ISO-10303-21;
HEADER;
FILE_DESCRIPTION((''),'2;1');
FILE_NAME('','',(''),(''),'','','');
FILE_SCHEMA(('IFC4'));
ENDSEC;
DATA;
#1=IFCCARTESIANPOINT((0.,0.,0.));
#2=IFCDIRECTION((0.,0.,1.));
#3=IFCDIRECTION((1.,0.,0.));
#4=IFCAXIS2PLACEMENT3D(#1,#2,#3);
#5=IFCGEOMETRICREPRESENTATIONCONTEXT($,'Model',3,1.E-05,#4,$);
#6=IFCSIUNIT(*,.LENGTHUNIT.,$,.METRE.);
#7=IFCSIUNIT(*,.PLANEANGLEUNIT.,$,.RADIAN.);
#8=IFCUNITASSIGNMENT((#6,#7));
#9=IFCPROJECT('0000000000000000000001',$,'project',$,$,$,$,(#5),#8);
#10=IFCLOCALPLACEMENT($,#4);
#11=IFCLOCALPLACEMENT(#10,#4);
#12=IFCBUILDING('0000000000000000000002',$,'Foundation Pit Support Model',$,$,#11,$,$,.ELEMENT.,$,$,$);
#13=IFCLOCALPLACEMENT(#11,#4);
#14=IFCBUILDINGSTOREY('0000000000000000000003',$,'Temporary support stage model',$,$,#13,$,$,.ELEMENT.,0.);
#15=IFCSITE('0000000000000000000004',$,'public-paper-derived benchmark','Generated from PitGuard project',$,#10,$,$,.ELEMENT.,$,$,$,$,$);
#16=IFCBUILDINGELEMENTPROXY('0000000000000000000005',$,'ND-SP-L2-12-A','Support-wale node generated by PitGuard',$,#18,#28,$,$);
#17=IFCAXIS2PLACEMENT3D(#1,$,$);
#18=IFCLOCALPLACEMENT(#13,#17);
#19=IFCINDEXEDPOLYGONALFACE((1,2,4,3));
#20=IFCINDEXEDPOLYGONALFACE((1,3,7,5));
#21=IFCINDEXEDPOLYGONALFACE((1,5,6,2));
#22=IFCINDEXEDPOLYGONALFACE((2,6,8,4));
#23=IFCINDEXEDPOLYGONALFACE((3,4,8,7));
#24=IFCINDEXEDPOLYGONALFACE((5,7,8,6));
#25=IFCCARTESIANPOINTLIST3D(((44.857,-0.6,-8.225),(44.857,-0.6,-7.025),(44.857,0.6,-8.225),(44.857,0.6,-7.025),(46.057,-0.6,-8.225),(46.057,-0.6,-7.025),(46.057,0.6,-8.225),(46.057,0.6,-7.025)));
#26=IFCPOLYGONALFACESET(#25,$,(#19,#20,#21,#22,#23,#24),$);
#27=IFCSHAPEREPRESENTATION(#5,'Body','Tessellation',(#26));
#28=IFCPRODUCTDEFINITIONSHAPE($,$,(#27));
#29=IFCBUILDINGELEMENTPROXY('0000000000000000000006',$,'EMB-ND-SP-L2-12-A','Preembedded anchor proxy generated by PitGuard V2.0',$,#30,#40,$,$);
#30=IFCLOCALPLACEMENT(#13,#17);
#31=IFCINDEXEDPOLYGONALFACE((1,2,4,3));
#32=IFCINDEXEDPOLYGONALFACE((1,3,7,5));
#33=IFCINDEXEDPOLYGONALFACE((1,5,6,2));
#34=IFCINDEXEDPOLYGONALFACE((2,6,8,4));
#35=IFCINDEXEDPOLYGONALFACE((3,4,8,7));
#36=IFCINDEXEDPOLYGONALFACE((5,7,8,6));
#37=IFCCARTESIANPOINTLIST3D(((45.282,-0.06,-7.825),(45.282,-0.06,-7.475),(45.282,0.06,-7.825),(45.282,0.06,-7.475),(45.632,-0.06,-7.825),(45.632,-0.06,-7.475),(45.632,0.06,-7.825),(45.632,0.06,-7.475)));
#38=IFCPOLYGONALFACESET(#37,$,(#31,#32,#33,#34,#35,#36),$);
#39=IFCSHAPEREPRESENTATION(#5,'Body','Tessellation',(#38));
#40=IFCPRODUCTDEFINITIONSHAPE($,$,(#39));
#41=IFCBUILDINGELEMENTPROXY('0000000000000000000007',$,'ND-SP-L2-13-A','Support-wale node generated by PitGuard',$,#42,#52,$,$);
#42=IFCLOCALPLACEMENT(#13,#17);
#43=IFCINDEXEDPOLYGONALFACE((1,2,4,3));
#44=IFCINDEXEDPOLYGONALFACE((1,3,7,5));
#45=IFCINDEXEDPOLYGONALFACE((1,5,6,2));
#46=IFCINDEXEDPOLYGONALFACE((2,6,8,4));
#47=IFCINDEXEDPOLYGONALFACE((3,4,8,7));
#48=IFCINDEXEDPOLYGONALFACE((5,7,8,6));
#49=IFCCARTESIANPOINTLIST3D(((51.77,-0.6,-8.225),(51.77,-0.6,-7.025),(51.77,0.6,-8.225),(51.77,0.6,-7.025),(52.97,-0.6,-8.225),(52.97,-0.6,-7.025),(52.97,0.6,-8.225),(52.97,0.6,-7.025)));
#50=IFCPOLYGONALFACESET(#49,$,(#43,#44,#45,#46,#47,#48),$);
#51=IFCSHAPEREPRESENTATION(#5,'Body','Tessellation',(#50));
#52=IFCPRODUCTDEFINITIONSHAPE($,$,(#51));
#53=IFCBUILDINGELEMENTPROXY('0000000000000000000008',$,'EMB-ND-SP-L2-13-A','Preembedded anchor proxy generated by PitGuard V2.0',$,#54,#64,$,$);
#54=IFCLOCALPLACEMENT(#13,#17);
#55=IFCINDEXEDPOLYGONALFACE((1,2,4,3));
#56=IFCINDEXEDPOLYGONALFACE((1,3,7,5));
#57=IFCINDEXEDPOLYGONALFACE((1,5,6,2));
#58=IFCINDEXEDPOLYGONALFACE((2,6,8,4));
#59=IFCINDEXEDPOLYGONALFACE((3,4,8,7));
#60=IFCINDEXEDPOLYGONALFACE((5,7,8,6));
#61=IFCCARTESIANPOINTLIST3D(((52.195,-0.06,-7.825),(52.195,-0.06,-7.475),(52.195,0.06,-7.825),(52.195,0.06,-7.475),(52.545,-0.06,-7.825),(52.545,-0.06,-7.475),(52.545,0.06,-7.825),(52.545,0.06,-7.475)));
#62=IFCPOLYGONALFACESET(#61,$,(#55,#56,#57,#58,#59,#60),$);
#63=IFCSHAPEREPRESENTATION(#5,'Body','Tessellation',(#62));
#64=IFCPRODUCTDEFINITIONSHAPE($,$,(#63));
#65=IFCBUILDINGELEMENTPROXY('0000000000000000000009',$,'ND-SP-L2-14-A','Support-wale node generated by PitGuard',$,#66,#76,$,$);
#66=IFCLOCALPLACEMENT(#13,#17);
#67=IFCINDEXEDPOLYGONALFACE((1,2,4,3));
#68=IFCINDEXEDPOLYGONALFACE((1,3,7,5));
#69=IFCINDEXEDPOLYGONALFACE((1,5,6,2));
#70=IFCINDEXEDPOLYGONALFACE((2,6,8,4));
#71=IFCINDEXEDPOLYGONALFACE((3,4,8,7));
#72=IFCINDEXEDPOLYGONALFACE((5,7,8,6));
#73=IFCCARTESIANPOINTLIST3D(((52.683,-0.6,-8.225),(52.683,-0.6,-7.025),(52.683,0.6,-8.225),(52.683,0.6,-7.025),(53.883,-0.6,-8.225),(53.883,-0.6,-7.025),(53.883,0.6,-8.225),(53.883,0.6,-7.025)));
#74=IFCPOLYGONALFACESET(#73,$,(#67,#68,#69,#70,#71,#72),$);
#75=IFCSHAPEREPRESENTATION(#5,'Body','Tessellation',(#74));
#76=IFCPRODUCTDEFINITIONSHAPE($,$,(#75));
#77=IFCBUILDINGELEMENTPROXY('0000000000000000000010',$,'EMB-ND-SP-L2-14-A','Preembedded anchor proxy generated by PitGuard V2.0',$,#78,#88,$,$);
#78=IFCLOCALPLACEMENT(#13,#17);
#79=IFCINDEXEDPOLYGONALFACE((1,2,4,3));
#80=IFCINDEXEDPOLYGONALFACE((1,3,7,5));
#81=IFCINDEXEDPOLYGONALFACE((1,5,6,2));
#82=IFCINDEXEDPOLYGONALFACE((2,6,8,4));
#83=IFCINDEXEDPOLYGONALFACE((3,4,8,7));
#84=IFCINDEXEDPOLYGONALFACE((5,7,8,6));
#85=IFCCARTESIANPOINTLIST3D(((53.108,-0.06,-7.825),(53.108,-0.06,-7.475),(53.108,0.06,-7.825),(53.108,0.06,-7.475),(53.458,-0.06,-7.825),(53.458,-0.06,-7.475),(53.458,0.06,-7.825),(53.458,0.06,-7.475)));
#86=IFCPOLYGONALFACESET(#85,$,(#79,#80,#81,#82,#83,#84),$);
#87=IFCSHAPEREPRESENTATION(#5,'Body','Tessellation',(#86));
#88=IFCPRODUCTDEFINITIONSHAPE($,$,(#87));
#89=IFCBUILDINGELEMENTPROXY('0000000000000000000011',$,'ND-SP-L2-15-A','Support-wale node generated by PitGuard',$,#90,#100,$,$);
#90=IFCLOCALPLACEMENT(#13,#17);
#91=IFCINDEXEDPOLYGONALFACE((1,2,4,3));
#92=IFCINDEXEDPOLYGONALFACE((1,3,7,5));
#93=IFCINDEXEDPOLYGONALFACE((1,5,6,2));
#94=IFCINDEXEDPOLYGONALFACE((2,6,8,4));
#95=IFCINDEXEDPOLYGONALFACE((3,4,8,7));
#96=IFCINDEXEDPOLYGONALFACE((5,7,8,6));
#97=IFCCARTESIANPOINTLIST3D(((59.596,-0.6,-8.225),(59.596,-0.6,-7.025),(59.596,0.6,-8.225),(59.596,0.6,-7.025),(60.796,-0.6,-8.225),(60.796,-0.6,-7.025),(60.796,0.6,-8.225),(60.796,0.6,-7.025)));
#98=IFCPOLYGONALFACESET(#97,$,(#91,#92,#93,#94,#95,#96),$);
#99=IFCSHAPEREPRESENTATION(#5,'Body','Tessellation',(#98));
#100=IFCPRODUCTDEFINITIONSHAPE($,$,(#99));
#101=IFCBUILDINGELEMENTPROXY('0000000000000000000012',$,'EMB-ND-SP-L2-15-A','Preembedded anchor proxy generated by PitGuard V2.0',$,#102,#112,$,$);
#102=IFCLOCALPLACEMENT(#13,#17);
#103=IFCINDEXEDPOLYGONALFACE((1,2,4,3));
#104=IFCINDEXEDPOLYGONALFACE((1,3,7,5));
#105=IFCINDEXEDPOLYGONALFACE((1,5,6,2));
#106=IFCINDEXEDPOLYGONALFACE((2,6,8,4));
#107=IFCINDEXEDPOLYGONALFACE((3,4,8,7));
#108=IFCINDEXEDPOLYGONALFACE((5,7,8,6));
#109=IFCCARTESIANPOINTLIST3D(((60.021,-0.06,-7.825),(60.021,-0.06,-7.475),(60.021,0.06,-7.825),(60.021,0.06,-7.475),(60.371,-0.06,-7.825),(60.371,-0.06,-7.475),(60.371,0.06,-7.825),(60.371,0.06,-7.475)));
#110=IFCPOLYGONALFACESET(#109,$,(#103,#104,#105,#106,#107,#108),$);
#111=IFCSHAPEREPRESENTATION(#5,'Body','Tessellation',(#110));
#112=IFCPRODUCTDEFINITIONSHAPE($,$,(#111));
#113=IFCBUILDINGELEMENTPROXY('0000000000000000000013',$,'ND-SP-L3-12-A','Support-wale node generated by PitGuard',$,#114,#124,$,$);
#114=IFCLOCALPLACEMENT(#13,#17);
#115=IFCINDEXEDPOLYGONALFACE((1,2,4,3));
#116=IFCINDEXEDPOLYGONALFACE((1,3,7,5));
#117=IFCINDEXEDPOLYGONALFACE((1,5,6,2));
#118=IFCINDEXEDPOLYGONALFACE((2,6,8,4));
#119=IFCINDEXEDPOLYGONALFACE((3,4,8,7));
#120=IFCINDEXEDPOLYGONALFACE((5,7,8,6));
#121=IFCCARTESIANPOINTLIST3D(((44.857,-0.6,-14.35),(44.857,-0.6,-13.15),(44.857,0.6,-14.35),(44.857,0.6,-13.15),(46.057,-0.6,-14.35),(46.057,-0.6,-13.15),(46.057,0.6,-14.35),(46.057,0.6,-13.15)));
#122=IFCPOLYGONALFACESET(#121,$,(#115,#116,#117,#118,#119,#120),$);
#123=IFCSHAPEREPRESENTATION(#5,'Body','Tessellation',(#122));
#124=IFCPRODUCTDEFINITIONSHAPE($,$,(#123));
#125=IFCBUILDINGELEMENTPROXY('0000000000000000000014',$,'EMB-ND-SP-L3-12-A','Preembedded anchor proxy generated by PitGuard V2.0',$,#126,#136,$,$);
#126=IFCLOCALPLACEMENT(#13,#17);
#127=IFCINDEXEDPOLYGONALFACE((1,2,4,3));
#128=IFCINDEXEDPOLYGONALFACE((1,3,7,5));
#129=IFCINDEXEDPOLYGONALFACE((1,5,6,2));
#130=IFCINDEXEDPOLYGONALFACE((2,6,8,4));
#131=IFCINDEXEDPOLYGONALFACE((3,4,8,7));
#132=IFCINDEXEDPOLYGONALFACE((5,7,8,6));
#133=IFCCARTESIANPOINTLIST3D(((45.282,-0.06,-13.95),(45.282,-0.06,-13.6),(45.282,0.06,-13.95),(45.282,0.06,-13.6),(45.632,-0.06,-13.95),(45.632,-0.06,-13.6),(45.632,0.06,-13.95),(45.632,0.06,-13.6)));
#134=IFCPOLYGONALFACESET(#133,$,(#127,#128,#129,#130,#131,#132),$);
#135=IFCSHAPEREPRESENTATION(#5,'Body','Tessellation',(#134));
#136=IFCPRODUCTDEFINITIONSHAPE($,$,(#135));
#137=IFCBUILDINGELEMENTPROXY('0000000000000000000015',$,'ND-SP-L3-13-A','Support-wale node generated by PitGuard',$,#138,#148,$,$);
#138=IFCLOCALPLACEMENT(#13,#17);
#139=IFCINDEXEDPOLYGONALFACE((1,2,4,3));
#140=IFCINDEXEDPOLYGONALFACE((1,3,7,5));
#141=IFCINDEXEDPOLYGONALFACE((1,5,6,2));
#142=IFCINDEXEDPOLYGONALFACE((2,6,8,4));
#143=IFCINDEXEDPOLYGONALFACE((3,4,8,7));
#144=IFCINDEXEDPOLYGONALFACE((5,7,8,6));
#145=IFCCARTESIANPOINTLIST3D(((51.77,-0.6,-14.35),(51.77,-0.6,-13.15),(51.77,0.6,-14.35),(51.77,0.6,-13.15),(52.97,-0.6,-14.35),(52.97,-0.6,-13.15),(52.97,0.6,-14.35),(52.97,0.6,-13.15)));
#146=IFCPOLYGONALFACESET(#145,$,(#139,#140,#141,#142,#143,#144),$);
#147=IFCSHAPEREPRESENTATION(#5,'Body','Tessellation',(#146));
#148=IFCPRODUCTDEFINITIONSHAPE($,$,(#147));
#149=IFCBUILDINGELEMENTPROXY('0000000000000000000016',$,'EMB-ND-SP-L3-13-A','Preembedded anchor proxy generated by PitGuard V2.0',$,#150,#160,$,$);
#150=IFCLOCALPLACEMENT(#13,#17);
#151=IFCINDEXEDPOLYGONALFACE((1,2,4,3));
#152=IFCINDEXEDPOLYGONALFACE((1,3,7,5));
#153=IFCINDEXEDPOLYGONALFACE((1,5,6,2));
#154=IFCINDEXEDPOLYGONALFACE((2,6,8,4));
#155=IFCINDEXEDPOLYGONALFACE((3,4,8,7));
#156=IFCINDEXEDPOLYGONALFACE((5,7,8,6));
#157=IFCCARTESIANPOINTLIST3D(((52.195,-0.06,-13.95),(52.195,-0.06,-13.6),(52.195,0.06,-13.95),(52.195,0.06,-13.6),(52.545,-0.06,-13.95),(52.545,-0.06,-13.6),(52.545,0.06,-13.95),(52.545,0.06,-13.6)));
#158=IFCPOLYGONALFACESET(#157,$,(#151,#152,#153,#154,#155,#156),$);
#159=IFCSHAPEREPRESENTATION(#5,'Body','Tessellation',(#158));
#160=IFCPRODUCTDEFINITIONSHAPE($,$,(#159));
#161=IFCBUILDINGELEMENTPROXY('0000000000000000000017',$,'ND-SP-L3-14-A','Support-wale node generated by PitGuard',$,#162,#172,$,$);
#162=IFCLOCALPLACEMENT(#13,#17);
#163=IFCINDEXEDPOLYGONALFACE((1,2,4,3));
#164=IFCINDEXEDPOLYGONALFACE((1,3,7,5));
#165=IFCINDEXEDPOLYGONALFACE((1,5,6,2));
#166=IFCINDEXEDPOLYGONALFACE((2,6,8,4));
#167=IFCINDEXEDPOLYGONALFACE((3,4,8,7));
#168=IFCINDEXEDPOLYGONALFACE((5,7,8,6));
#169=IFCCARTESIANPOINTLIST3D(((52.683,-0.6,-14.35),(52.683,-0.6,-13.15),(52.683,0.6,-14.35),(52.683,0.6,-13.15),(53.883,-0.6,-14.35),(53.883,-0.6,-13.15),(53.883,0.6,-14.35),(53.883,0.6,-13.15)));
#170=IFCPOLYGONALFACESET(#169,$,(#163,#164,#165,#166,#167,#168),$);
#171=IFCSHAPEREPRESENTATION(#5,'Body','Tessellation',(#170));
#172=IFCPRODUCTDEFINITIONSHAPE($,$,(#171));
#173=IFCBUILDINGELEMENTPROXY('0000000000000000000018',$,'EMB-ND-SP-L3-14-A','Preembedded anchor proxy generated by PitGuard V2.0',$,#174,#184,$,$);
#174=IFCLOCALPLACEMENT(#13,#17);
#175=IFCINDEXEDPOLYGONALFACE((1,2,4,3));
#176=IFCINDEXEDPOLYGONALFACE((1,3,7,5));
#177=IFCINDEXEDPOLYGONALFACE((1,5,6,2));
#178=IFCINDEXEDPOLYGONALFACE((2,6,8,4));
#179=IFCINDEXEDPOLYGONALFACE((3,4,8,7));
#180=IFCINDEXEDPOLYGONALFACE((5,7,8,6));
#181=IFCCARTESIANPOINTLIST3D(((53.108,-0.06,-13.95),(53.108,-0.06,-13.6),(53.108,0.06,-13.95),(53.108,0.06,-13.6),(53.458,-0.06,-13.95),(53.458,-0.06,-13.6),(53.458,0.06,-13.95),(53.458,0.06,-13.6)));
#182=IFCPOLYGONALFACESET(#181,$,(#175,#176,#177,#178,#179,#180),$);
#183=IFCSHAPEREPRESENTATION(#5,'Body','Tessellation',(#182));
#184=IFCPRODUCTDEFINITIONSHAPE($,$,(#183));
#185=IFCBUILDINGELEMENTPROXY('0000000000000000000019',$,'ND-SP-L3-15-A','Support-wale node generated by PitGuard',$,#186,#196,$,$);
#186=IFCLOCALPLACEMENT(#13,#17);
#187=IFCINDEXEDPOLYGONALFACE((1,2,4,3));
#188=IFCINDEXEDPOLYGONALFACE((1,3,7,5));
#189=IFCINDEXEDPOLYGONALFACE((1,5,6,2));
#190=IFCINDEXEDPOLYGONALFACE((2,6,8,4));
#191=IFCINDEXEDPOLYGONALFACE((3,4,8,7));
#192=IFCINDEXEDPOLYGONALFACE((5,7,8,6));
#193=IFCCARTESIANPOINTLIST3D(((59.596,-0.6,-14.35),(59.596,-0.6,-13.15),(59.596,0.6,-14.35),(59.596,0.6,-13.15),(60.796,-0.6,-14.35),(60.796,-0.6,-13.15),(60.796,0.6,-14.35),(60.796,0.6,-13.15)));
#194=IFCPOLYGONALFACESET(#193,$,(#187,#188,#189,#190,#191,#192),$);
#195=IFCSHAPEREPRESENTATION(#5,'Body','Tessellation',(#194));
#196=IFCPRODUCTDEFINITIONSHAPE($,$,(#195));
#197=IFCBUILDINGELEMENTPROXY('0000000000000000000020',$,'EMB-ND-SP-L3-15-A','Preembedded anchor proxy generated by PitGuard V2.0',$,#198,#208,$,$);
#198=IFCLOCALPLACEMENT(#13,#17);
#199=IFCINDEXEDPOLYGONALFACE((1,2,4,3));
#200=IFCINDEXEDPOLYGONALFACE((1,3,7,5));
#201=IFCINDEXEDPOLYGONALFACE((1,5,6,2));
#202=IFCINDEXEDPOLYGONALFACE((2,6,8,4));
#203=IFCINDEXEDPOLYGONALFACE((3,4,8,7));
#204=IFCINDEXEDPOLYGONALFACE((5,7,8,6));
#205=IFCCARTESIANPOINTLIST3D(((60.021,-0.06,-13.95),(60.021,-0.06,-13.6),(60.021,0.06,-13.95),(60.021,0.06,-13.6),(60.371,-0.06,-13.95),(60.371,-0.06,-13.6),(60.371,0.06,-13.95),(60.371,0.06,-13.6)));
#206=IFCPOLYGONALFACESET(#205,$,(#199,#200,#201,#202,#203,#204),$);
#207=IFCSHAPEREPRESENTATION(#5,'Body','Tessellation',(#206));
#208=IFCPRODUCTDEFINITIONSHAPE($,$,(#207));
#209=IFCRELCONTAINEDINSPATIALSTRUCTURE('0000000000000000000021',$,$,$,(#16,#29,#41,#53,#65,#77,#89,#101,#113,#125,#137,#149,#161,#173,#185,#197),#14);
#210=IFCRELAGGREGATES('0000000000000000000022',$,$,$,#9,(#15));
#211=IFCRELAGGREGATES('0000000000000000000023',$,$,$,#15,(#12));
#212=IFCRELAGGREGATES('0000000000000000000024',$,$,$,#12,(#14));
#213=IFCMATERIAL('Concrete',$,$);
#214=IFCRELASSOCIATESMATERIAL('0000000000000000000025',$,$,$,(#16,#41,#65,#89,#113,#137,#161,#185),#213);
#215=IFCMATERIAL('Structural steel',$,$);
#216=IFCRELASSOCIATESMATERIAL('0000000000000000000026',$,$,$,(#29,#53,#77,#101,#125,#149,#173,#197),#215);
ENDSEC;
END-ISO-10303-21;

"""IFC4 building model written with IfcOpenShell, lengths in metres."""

from ifc_helpers import new_model, si_unit, frame, origin_with_axes, origin_2d, place, context, project, spatial, rectangle, extrude, material, element, save


model = new_model("IFC4")

# Units and contexts
model_context = context("Model", 3, precision=1e-05, world=origin_with_axes())
ifc_project = project(units=[si_unit("LENGTHUNIT", "METRE"), si_unit("PLANEANGLEUNIT", "RADIAN")], contexts=[model_context])

# Site, building, storey
site_placement = place(None, origin_with_axes())
site = spatial("IfcSite", under=ifc_project, at=site_placement, Name="public-paper-derived benchmark", Description="Generated from PitGuard project", CompositionType="ELEMENT")
building_placement = place(site_placement, origin_with_axes())
building = spatial("IfcBuilding", under=site, at=building_placement, Name="Foundation Pit Support Model", CompositionType="ELEMENT")
storey_placement = place(building_placement, origin_with_axes())
storey = spatial("IfcBuildingStorey", under=building, at=storey_placement, Name="Temporary support stage model", CompositionType="ELEMENT", Elevation=0.0)

# Shared definitions
ifc_material_1 = material(Name="Concrete")

# Shared definitions
ifc_material_2 = material(Name="Structural steel")

# Building element proxies
for number, where, z_axis, x_axis, name in (
    (1, (45.457, 0.0, -8.225), (0.0, 0.0, 1.0), (1.0, 0.0, 0.0), "ND-SP-L2-12-A"),
):
    element("IfcBuildingElementProxy", number, at=place(storey_placement, frame(where, z_axis=z_axis, x_axis=x_axis)), inside=storey, material=ifc_material_1, Name=name, Description="Support-wale node generated by PitGuard", context=model_context, shape_type="SweptSolid", body=[
        extrude(rectangle(XDim=1.2, YDim=1.2, at=origin_2d()), origin_with_axes(), (0.0, 0.0, 1.0), 1.2),
    ])
proxy_1_placement = place(storey_placement, frame((45.457, 0.0, -7.825), z_axis=(0.0, 0.0, 1.0), x_axis=(1.0, 0.0, 0.0)))
element("IfcBuildingElementProxy", 2, at=proxy_1_placement, inside=storey, material=ifc_material_2, Name="EMB-ND-SP-L2-12-A", Description="Preembedded anchor proxy generated by PitGuard V2.0", context=model_context, shape_type="SweptSolid", body=[
    extrude(rectangle(XDim=0.35, YDim=0.12, at=origin_2d()), origin_with_axes(), (0.0, 0.0, 1.0), 0.35),
])
proxy_2_placement = place(storey_placement, frame((52.37, 0.0, -8.225), z_axis=(0.0, 0.0, 1.0), x_axis=(1.0, 0.0, 0.0)))
element("IfcBuildingElementProxy", 3, at=proxy_2_placement, inside=storey, material=ifc_material_1, Name="ND-SP-L2-13-A", Description="Support-wale node generated by PitGuard", context=model_context, shape_type="SweptSolid", body=[
    extrude(rectangle(XDim=1.2, YDim=1.2, at=origin_2d()), origin_with_axes(), (0.0, 0.0, 1.0), 1.2),
])
proxy_3_placement = place(storey_placement, frame((52.37, 0.0, -7.825), z_axis=(0.0, 0.0, 1.0), x_axis=(1.0, 0.0, 0.0)))
element("IfcBuildingElementProxy", 4, at=proxy_3_placement, inside=storey, material=ifc_material_2, Name="EMB-ND-SP-L2-13-A", Description="Preembedded anchor proxy generated by PitGuard V2.0", context=model_context, shape_type="SweptSolid", body=[
    extrude(rectangle(XDim=0.35, YDim=0.12, at=origin_2d()), origin_with_axes(), (0.0, 0.0, 1.0), 0.35),
])
proxy_4_placement = place(storey_placement, frame((53.283, 0.0, -8.225), z_axis=(0.0, 0.0, 1.0), x_axis=(1.0, 0.0, 0.0)))
element("IfcBuildingElementProxy", 5, at=proxy_4_placement, inside=storey, material=ifc_material_1, Name="ND-SP-L2-14-A", Description="Support-wale node generated by PitGuard", context=model_context, shape_type="SweptSolid", body=[
    extrude(rectangle(XDim=1.2, YDim=1.2, at=origin_2d()), origin_with_axes(), (0.0, 0.0, 1.0), 1.2),
])
proxy_5_placement = place(storey_placement, frame((53.283, 0.0, -7.825), z_axis=(0.0, 0.0, 1.0), x_axis=(1.0, 0.0, 0.0)))
element("IfcBuildingElementProxy", 6, at=proxy_5_placement, inside=storey, material=ifc_material_2, Name="EMB-ND-SP-L2-14-A", Description="Preembedded anchor proxy generated by PitGuard V2.0", context=model_context, shape_type="SweptSolid", body=[
    extrude(rectangle(XDim=0.35, YDim=0.12, at=origin_2d()), origin_with_axes(), (0.0, 0.0, 1.0), 0.35),
])
proxy_6_placement = place(storey_placement, frame((60.196, 0.0, -8.225), z_axis=(0.0, 0.0, 1.0), x_axis=(1.0, 0.0, 0.0)))
element("IfcBuildingElementProxy", 7, at=proxy_6_placement, inside=storey, material=ifc_material_1, Name="ND-SP-L2-15-A", Description="Support-wale node generated by PitGuard", context=model_context, shape_type="SweptSolid", body=[
    extrude(rectangle(XDim=1.2, YDim=1.2, at=origin_2d()), origin_with_axes(), (0.0, 0.0, 1.0), 1.2),
])
proxy_7_placement = place(storey_placement, frame((60.196, 0.0, -7.825), z_axis=(0.0, 0.0, 1.0), x_axis=(1.0, 0.0, 0.0)))
element("IfcBuildingElementProxy", 8, at=proxy_7_placement, inside=storey, material=ifc_material_2, Name="EMB-ND-SP-L2-15-A", Description="Preembedded anchor proxy generated by PitGuard V2.0", context=model_context, shape_type="SweptSolid", body=[
    extrude(rectangle(XDim=0.35, YDim=0.12, at=origin_2d()), origin_with_axes(), (0.0, 0.0, 1.0), 0.35),
])
proxy_8_placement = place(storey_placement, frame((45.457, 0.0, -14.35), z_axis=(0.0, 0.0, 1.0), x_axis=(1.0, 0.0, 0.0)))
element("IfcBuildingElementProxy", 9, at=proxy_8_placement, inside=storey, material=ifc_material_1, Name="ND-SP-L3-12-A", Description="Support-wale node generated by PitGuard", context=model_context, shape_type="SweptSolid", body=[
    extrude(rectangle(XDim=1.2, YDim=1.2, at=origin_2d()), origin_with_axes(), (0.0, 0.0, 1.0), 1.2),
])
proxy_9_placement = place(storey_placement, frame((45.457, 0.0, -13.95), z_axis=(0.0, 0.0, 1.0), x_axis=(1.0, 0.0, 0.0)))
element("IfcBuildingElementProxy", 10, at=proxy_9_placement, inside=storey, material=ifc_material_2, Name="EMB-ND-SP-L3-12-A", Description="Preembedded anchor proxy generated by PitGuard V2.0", context=model_context, shape_type="SweptSolid", body=[
    extrude(rectangle(XDim=0.35, YDim=0.12, at=origin_2d()), origin_with_axes(), (0.0, 0.0, 1.0), 0.35),
])
proxy_10_placement = place(storey_placement, frame((52.37, 0.0, -14.35), z_axis=(0.0, 0.0, 1.0), x_axis=(1.0, 0.0, 0.0)))
element("IfcBuildingElementProxy", 11, at=proxy_10_placement, inside=storey, material=ifc_material_1, Name="ND-SP-L3-13-A", Description="Support-wale node generated by PitGuard", context=model_context, shape_type="SweptSolid", body=[
    extrude(rectangle(XDim=1.2, YDim=1.2, at=origin_2d()), origin_with_axes(), (0.0, 0.0, 1.0), 1.2),
])
proxy_11_placement = place(storey_placement, frame((52.37, 0.0, -13.95), z_axis=(0.0, 0.0, 1.0), x_axis=(1.0, 0.0, 0.0)))
element("IfcBuildingElementProxy", 12, at=proxy_11_placement, inside=storey, material=ifc_material_2, Name="EMB-ND-SP-L3-13-A", Description="Preembedded anchor proxy generated by PitGuard V2.0", context=model_context, shape_type="SweptSolid", body=[
    extrude(rectangle(XDim=0.35, YDim=0.12, at=origin_2d()), origin_with_axes(), (0.0, 0.0, 1.0), 0.35),
])
proxy_12_placement = place(storey_placement, frame((53.283, 0.0, -14.35), z_axis=(0.0, 0.0, 1.0), x_axis=(1.0, 0.0, 0.0)))
element("IfcBuildingElementProxy", 13, at=proxy_12_placement, inside=storey, material=ifc_material_1, Name="ND-SP-L3-14-A", Description="Support-wale node generated by PitGuard", context=model_context, shape_type="SweptSolid", body=[
    extrude(rectangle(XDim=1.2, YDim=1.2, at=origin_2d()), origin_with_axes(), (0.0, 0.0, 1.0), 1.2),
])
proxy_13_placement = place(storey_placement, frame((53.283, 0.0, -13.95), z_axis=(0.0, 0.0, 1.0), x_axis=(1.0, 0.0, 0.0)))
element("IfcBuildingElementProxy", 14, at=proxy_13_placement, inside=storey, material=ifc_material_2, Name="EMB-ND-SP-L3-14-A", Description="Preembedded anchor proxy generated by PitGuard V2.0", context=model_context, shape_type="SweptSolid", body=[
    extrude(rectangle(XDim=0.35, YDim=0.12, at=origin_2d()), origin_with_axes(), (0.0, 0.0, 1.0), 0.35),
])
proxy_14_placement = place(storey_placement, frame((60.196, 0.0, -14.35), z_axis=(0.0, 0.0, 1.0), x_axis=(1.0, 0.0, 0.0)))
element("IfcBuildingElementProxy", 15, at=proxy_14_placement, inside=storey, material=ifc_material_1, Name="ND-SP-L3-15-A", Description="Support-wale node generated by PitGuard", context=model_context, shape_type="SweptSolid", body=[
    extrude(rectangle(XDim=1.2, YDim=1.2, at=origin_2d()), origin_with_axes(), (0.0, 0.0, 1.0), 1.2),
])
proxy_15_placement = place(storey_placement, frame((60.196, 0.0, -13.95), z_axis=(0.0, 0.0, 1.0), x_axis=(1.0, 0.0, 0.0)))
element("IfcBuildingElementProxy", 16, at=proxy_15_placement, inside=storey, material=ifc_material_2, Name="EMB-ND-SP-L3-15-A", Description="Preembedded anchor proxy generated by PitGuard V2.0", context=model_context, shape_type="SweptSolid", body=[
    extrude(rectangle(XDim=0.35, YDim=0.12, at=origin_2d()), origin_with_axes(), (0.0, 0.0, 1.0), 0.35),
])

save(model, "model.ifc")
